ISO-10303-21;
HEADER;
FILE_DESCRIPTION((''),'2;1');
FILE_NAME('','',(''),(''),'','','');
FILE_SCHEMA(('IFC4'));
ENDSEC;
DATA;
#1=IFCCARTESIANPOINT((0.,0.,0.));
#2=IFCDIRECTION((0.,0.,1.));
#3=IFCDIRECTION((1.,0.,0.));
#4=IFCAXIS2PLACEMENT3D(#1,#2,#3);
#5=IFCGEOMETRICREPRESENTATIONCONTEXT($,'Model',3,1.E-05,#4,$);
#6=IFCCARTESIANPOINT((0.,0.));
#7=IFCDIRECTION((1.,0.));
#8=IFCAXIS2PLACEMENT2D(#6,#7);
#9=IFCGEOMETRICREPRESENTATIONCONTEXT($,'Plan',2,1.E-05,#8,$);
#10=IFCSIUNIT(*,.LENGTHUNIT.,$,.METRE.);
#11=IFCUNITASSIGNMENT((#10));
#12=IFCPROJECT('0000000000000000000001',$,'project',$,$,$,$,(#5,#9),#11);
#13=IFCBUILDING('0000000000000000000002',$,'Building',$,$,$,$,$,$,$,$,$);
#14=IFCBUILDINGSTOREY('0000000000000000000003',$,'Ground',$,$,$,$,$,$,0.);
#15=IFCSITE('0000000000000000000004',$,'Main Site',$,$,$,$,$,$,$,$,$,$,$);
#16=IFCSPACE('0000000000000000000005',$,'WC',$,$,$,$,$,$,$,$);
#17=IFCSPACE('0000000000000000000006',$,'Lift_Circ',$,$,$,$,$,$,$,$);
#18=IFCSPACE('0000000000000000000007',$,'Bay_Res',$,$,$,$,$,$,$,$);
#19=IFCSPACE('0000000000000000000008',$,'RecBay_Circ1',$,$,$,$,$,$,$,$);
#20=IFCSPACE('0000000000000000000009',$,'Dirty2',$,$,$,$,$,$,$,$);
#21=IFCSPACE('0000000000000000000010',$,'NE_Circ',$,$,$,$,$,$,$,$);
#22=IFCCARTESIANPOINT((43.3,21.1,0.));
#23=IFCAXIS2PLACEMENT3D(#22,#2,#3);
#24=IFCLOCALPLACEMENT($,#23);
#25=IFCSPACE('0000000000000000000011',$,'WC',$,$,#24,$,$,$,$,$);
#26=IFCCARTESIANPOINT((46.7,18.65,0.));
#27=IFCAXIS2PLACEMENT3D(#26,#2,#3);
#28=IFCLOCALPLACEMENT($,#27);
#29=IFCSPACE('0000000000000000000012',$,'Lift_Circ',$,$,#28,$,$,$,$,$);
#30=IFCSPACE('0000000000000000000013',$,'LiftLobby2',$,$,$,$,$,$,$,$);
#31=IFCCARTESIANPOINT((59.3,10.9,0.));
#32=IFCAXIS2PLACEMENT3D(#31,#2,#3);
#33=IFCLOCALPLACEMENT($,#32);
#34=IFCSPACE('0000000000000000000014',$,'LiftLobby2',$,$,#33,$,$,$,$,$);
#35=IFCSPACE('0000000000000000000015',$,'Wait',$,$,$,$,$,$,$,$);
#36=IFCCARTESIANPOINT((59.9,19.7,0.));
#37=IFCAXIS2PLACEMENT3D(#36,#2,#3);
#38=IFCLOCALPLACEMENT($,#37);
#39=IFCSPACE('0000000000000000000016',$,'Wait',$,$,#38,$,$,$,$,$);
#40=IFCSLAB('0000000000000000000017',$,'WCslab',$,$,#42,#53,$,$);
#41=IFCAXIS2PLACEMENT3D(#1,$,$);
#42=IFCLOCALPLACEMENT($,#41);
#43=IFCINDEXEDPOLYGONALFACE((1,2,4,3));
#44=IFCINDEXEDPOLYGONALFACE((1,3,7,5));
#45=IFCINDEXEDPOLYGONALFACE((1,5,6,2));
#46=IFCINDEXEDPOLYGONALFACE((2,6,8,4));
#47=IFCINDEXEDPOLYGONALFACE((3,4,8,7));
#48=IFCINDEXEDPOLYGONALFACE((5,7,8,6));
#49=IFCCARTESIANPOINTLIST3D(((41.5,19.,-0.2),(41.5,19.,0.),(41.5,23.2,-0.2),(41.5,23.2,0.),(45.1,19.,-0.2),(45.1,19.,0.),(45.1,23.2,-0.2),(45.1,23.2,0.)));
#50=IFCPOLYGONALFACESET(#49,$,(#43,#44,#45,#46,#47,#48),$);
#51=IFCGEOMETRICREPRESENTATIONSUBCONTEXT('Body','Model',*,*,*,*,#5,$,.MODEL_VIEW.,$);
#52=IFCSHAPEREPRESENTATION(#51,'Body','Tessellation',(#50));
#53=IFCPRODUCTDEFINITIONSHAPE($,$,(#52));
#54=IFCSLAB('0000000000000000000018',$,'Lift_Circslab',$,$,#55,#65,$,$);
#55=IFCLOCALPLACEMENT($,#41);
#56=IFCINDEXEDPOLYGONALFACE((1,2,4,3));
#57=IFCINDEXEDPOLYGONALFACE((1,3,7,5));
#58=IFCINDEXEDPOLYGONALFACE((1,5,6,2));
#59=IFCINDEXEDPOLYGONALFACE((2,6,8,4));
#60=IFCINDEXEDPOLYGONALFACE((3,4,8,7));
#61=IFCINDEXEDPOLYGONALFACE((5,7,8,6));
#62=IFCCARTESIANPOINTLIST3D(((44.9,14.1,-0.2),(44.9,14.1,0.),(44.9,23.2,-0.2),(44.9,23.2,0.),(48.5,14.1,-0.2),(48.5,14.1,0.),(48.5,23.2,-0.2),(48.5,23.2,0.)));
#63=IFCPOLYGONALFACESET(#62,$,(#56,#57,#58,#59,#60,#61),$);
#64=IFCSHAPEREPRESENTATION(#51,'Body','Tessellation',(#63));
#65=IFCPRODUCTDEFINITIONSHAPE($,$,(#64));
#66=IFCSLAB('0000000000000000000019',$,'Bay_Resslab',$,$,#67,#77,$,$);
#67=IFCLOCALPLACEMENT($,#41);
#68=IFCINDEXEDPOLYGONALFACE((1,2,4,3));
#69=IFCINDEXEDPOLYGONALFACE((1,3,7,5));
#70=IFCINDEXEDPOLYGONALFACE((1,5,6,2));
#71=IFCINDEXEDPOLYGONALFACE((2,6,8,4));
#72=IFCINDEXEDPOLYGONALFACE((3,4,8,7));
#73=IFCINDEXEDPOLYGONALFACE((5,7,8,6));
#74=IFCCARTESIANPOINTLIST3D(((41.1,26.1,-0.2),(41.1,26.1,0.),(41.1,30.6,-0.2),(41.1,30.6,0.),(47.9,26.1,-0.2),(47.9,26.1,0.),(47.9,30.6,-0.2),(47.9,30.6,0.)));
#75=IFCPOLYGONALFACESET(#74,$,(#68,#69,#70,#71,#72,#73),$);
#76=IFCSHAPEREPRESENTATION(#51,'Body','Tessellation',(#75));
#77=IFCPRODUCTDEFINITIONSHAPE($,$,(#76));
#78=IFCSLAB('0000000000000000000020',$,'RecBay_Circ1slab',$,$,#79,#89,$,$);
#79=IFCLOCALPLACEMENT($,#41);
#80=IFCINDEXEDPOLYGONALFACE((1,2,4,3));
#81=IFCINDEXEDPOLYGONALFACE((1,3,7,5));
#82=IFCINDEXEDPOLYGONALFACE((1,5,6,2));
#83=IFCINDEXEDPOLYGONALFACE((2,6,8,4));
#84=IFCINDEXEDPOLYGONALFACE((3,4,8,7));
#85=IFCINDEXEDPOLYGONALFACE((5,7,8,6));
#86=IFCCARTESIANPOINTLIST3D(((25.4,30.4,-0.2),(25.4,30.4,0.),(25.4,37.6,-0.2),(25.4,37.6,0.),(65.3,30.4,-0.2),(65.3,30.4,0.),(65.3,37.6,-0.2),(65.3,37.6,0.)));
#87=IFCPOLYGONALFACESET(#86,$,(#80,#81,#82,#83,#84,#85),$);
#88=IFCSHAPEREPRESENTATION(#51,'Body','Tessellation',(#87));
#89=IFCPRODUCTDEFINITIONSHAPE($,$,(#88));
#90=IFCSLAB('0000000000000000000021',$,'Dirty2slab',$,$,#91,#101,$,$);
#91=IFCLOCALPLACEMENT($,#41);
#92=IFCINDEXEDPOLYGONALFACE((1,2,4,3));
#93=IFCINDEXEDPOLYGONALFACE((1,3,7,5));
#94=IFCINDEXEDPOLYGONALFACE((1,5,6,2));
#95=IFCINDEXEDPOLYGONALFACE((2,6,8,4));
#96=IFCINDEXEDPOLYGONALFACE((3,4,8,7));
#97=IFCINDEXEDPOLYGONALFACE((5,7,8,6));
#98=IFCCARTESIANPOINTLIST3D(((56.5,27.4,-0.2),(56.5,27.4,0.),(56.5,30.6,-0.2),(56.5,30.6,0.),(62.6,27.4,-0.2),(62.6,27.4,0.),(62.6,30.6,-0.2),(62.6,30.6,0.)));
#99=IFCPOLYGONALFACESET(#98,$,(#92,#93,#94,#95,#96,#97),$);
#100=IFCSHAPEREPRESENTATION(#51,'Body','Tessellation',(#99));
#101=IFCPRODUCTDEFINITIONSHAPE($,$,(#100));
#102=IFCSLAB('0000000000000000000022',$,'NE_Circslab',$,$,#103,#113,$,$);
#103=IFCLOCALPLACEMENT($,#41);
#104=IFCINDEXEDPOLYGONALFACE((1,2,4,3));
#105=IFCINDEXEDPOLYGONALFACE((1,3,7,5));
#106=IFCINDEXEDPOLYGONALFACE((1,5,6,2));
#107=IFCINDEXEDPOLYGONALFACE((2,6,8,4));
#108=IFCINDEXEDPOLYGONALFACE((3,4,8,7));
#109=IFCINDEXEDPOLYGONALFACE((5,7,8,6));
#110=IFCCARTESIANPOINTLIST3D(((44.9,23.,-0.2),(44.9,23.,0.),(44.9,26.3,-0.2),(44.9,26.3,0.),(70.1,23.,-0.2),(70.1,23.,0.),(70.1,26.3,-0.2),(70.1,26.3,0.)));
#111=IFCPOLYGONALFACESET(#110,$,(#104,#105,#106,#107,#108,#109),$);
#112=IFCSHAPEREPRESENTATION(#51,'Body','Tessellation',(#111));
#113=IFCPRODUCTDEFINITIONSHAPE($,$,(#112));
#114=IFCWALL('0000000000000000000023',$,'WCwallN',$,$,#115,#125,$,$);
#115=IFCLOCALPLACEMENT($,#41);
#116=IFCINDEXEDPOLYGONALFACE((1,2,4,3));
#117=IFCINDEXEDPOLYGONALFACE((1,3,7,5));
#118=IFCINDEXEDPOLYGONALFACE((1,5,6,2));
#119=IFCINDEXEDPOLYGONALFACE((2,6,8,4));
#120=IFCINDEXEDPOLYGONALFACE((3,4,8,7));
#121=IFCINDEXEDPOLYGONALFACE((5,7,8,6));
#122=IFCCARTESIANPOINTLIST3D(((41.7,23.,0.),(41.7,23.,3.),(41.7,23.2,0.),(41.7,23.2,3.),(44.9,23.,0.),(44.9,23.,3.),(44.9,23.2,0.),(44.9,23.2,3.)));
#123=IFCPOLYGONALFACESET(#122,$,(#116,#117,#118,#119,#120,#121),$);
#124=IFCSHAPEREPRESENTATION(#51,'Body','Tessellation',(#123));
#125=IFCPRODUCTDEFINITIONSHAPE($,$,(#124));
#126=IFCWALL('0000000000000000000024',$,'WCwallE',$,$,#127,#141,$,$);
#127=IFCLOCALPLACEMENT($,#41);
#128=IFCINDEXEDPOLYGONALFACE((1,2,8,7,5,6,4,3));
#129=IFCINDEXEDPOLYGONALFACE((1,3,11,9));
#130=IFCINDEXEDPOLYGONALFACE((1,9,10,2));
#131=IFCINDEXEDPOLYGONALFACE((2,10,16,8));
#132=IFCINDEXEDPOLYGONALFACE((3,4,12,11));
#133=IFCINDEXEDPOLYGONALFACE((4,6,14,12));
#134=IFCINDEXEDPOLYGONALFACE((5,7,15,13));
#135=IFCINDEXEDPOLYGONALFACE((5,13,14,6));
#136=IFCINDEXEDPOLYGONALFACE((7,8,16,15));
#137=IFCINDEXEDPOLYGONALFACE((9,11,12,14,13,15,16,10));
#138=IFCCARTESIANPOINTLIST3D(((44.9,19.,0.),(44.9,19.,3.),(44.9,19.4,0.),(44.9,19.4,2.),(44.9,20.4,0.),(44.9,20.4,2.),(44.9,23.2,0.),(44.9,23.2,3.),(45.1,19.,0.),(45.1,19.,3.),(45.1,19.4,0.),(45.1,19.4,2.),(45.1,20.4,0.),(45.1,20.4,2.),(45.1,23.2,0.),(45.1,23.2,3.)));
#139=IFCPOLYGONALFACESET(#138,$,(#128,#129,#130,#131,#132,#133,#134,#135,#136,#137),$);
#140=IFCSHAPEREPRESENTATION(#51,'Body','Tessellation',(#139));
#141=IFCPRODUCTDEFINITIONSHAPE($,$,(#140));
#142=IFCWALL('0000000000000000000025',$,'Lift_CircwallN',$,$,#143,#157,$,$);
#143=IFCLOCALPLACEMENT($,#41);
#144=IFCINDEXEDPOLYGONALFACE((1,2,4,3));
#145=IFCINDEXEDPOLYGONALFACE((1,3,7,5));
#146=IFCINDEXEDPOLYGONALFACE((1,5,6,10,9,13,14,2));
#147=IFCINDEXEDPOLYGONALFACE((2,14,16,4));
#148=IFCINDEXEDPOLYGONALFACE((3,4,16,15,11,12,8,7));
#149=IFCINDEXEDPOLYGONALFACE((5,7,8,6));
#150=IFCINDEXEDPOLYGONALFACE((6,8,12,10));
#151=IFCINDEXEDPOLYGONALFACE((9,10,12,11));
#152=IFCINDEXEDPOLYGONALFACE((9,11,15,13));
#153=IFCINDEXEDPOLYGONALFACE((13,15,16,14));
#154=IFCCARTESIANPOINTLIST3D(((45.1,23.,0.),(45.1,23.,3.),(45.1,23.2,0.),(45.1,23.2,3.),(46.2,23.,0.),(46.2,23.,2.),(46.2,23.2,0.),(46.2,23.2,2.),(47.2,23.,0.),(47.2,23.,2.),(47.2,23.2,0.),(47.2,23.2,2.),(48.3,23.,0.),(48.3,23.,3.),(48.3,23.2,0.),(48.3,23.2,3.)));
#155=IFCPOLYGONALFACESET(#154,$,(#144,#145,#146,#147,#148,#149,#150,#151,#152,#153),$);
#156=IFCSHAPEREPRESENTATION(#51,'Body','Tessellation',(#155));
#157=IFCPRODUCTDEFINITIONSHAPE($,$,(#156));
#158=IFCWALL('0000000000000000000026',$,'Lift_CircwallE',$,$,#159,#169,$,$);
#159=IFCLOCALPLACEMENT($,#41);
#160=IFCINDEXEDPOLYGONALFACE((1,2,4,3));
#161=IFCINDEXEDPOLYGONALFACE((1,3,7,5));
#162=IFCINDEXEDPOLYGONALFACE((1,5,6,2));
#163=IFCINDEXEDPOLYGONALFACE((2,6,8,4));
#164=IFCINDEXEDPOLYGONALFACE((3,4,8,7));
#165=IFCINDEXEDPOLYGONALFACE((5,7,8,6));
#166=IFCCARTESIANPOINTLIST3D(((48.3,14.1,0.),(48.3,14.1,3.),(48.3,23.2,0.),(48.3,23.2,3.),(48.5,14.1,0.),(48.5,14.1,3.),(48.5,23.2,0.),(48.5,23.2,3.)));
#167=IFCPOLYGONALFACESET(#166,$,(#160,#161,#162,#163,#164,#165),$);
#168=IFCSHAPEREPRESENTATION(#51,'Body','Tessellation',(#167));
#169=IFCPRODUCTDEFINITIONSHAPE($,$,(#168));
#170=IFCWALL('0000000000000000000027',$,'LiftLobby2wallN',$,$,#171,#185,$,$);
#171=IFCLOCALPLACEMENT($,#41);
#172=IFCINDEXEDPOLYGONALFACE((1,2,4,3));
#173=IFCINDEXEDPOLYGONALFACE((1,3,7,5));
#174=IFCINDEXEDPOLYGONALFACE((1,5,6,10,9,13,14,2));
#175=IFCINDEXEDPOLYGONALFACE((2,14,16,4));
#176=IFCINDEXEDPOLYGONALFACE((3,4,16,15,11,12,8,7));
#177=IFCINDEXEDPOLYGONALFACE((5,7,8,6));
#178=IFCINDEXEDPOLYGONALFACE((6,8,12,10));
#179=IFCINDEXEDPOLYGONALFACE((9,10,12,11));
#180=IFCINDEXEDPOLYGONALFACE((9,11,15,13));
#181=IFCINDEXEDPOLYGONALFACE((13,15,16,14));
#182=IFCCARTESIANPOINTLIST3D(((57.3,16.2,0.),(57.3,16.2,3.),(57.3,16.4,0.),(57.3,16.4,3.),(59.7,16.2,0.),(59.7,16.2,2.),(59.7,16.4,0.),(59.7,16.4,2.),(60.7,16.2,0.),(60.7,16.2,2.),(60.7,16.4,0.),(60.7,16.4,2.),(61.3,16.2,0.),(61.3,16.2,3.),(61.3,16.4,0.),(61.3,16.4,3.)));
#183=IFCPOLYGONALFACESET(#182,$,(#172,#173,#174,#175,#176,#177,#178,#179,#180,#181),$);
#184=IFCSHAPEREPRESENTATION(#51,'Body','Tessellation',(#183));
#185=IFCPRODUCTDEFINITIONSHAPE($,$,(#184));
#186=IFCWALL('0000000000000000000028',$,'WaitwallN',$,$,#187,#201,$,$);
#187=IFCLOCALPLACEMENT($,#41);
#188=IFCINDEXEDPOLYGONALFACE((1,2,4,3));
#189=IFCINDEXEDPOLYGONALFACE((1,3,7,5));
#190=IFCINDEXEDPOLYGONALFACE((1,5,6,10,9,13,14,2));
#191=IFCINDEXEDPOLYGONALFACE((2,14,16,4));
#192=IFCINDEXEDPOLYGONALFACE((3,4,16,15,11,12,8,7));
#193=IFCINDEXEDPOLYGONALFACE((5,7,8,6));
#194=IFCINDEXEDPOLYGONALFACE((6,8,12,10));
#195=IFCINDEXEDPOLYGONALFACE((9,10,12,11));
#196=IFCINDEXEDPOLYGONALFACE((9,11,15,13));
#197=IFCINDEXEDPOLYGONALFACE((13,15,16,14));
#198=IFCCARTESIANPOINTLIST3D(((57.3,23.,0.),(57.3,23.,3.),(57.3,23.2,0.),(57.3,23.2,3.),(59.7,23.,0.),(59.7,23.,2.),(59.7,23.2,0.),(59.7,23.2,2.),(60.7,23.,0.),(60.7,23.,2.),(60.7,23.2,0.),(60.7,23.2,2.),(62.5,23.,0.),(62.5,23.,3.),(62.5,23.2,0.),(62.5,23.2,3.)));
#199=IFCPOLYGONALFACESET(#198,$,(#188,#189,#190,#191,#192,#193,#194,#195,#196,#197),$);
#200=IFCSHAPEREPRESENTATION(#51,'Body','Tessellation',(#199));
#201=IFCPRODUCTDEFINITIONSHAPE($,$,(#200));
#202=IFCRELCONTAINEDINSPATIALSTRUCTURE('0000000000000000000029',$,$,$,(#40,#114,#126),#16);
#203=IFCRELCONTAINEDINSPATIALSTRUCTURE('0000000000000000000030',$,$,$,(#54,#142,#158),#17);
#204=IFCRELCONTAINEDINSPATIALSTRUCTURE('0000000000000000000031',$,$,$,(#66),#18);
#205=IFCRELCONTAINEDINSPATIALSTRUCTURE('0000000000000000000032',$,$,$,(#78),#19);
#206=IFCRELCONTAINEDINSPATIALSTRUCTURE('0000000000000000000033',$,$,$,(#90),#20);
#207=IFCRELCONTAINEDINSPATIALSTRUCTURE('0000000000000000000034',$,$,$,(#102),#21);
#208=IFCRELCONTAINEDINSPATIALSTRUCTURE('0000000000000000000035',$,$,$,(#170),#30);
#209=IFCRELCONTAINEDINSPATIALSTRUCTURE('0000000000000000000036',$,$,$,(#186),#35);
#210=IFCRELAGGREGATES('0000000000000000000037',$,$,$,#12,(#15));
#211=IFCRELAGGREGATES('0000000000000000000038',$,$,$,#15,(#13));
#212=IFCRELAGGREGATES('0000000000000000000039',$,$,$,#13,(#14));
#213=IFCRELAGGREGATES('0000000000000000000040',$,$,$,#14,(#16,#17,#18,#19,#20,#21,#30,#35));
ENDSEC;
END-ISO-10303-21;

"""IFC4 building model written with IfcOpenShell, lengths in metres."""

from ifc_helpers import new_model, si_unit, frame, origin_with_axes, origin_2d_with_axis, place, context, subcontext, project, spatial, indexed_curve, rectangle, outline, extrude, element, save


model = new_model("IFC4")

# Units and contexts
model_context = context("Model", 3, precision=1e-05, world=origin_with_axes())
plan_context = context("Plan", 2, precision=1e-05, world=origin_2d_with_axis())
body_context = subcontext(model_context, "Body", "Model", "MODEL_VIEW")
ifc_project = project(units=[si_unit("LENGTHUNIT", "METRE")], contexts=[model_context, plan_context])

# Site, building, storey, space
site = spatial("IfcSite", under=ifc_project, Name="Main Site")
building = spatial("IfcBuilding", under=site, Name="Building")
storey = spatial("IfcBuildingStorey", under=building, Name="Ground", Elevation=0.0)
space_1 = spatial("IfcSpace", under=storey, Name="WC")

# Slab
slab_1_placement = place(None, frame((43.3, 21.1, -0.2), z_axis=(0.0, 0.0, 1.0), x_axis=(1.0, 0.0, 0.0)))
element("IfcSlab", 1, at=slab_1_placement, inside=space_1, Name="WCslab", context=body_context, shape_type="SweptSolid", body=[
    extrude(rectangle(XDim=3.6, YDim=4.2), origin_with_axes(), (0.0, 0.0, 1.0), 0.2),
])

# Shared definitions
space_2 = spatial("IfcSpace", under=storey, Name="Lift_Circ")

# Slab
slab_2_placement = place(None, frame((46.7, 18.65, -0.2), z_axis=(0.0, 0.0, 1.0), x_axis=(1.0, 0.0, 0.0)))
element("IfcSlab", 2, at=slab_2_placement, inside=space_2, Name="Lift_Circslab", context=body_context, shape_type="SweptSolid", body=[
    extrude(rectangle(XDim=3.6, YDim=9.1), origin_with_axes(), (0.0, 0.0, 1.0), 0.2),
])

# Shared definitions
space_3 = spatial("IfcSpace", under=storey, Name="Bay_Res")

# Slab
slab_3_placement = place(None, frame((44.5, 28.35, -0.2), z_axis=(0.0, 0.0, 1.0), x_axis=(1.0, 0.0, 0.0)))
element("IfcSlab", 3, at=slab_3_placement, inside=space_3, Name="Bay_Resslab", context=body_context, shape_type="SweptSolid", body=[
    extrude(rectangle(XDim=6.8, YDim=4.5), origin_with_axes(), (0.0, 0.0, 1.0), 0.2),
])

# Shared definitions
space_4 = spatial("IfcSpace", under=storey, Name="RecBay_Circ1")

# Slab
slab_4_placement = place(None, frame((45.35, 34.0, -0.2), z_axis=(0.0, 0.0, 1.0), x_axis=(1.0, 0.0, 0.0)))
element("IfcSlab", 4, at=slab_4_placement, inside=space_4, Name="RecBay_Circ1slab", context=body_context, shape_type="SweptSolid", body=[
    extrude(rectangle(XDim=39.9, YDim=7.2), origin_with_axes(), (0.0, 0.0, 1.0), 0.2),
])

# Shared definitions
space_5 = spatial("IfcSpace", under=storey, Name="Dirty2")

# Slab
slab_5_placement = place(None, frame((59.55, 29.0, -0.2), z_axis=(0.0, 0.0, 1.0), x_axis=(1.0, 0.0, 0.0)))
element("IfcSlab", 5, at=slab_5_placement, inside=space_5, Name="Dirty2slab", context=body_context, shape_type="SweptSolid", body=[
    extrude(rectangle(XDim=6.1, YDim=3.2), origin_with_axes(), (0.0, 0.0, 1.0), 0.2),
])

# Shared definitions
space_6 = spatial("IfcSpace", under=storey, Name="NE_Circ")

# Slab
slab_6_placement = place(None, frame((57.5, 24.65, -0.2), z_axis=(0.0, 0.0, 1.0), x_axis=(1.0, 0.0, 0.0)))
element("IfcSlab", 6, at=slab_6_placement, inside=space_6, Name="NE_Circslab", context=body_context, shape_type="SweptSolid", body=[
    extrude(rectangle(XDim=25.2, YDim=3.3), origin_with_axes(), (0.0, 0.0, 1.0), 0.2),
])

# Walls
wall_1_placement = place(None, frame((41.7, 23.0, 0.0), z_axis=(0.0, 0.0, 1.0), x_axis=(1.0, 0.0, 0.0)))
element("IfcWall", 7, at=wall_1_placement, inside=space_1, Name="WCwallN", context=body_context, shape_type="SweptSolid", body=[
    extrude(outline(indexed_curve([(0.0, 0.0), (0.0, 0.2), (3.2, 0.2), (3.2, 0.0), (0.0, 0.0)], self_intersect=False)), origin_with_axes(), (0.0, 0.0, 1.0), 3.0),
])
wall_2_placement = place(None, frame((45.1, 19.0, 0.0), z_axis=(0.0, 0.0, 1.0), x_axis=(0.0, 1.0, 0.0)))
wall_2 = element("IfcWall", 8, at=wall_2_placement, inside=space_1, Name="WCwallE", context=body_context, shape_type="SweptSolid", body=[
    extrude(outline(indexed_curve([(0.0, 0.0), (0.0, 0.2), (4.2, 0.2), (4.2, 0.0), (0.0, 0.0)], self_intersect=False)), origin_with_axes(), (0.0, 0.0, 1.0), 3.0),
])

# Shared definitions
space_7_placement = place(None, frame((43.3, 21.1, 0.0), z_axis=(0.0, 0.0, 1.0), x_axis=(1.0, 0.0, 0.0)))
space_7 = spatial("IfcSpace", at=space_7_placement, Name="WC")

# Opening
opening_1_placement = place(wall_2_placement, frame((0.4, 0.0, 0.0), z_axis=(0.0, 0.0, 1.0), x_axis=(1.0, 0.0, 0.0)))
element("IfcOpeningElement", 9, at=opening_1_placement, inside=space_7, cuts=wall_2, context=body_context, shape_type="SweptSolid", body=[
    extrude(outline(indexed_curve([(0.0, 0.0), (0.0, 0.4), (1.0, 0.4), (1.0, 0.0), (0.0, 0.0)], self_intersect=False)), origin_with_axes(), (0.0, 0.0, 1.0), 2.0),
])

# Wall
wall_3_placement = place(None, frame((45.1, 23.0, 0.0), z_axis=(0.0, 0.0, 1.0), x_axis=(1.0, 0.0, 0.0)))
wall_3 = element("IfcWall", 10, at=wall_3_placement, inside=space_2, Name="Lift_CircwallN", context=body_context, shape_type="SweptSolid", body=[
    extrude(outline(indexed_curve([(0.0, 0.0), (0.0, 0.2), (3.2, 0.2), (3.2, 0.0), (0.0, 0.0)], self_intersect=False)), origin_with_axes(), (0.0, 0.0, 1.0), 3.0),
])

# Shared definitions
space_8_placement = place(None, frame((46.7, 18.65, 0.0), z_axis=(0.0, 0.0, 1.0), x_axis=(1.0, 0.0, 0.0)))
space_8 = spatial("IfcSpace", at=space_8_placement, Name="Lift_Circ")

# Opening
opening_2_placement = place(wall_3_placement, frame((1.1, 0.0, 0.0), z_axis=(0.0, 0.0, 1.0), x_axis=(1.0, 0.0, 0.0)))
element("IfcOpeningElement", 11, at=opening_2_placement, inside=space_8, cuts=wall_3, context=body_context, shape_type="SweptSolid", body=[
    extrude(outline(indexed_curve([(0.0, 0.0), (0.0, 0.4), (1.0, 0.4), (1.0, 0.0), (0.0, 0.0)], self_intersect=False)), origin_with_axes(), (0.0, 0.0, 1.0), 2.0),
])

# Wall
wall_4_placement = place(None, frame((48.5, 14.1, 0.0), z_axis=(0.0, 0.0, 1.0), x_axis=(0.0, 1.0, 0.0)))
element("IfcWall", 12, at=wall_4_placement, inside=space_2, Name="Lift_CircwallE", context=body_context, shape_type="SweptSolid", body=[
    extrude(outline(indexed_curve([(0.0, 0.0), (0.0, 0.2), (9.1, 0.2), (9.1, 0.0), (0.0, 0.0)], self_intersect=False)), origin_with_axes(), (0.0, 0.0, 1.0), 3.0),
])

# Shared definitions
space_9 = spatial("IfcSpace", under=storey, Name="LiftLobby2")

# Wall
wall_5_placement = place(None, frame((57.3, 16.2, 0.0), z_axis=(0.0, 0.0, 1.0), x_axis=(1.0, 0.0, 0.0)))
wall_5 = element("IfcWall", 13, at=wall_5_placement, inside=space_9, Name="LiftLobby2wallN", context=body_context, shape_type="SweptSolid", body=[
    extrude(outline(indexed_curve([(0.0, 0.0), (0.0, 0.2), (4.0, 0.2), (4.0, 0.0), (0.0, 0.0)], self_intersect=False)), origin_with_axes(), (0.0, 0.0, 1.0), 3.0),
])

# Shared definitions
space_10_placement = place(None, frame((59.3, 10.9, 0.0), z_axis=(0.0, 0.0, 1.0), x_axis=(1.0, 0.0, 0.0)))
space_10 = spatial("IfcSpace", at=space_10_placement, Name="LiftLobby2")

# Opening
opening_3_placement = place(wall_5_placement, frame((2.4, 0.0, 0.0), z_axis=(0.0, 0.0, 1.0), x_axis=(1.0, 0.0, 0.0)))
element("IfcOpeningElement", 14, at=opening_3_placement, inside=space_10, cuts=wall_5, context=body_context, shape_type="SweptSolid", body=[
    extrude(outline(indexed_curve([(0.0, 0.0), (0.0, 0.4), (1.0, 0.4), (1.0, 0.0), (0.0, 0.0)], self_intersect=False)), origin_with_axes(), (0.0, 0.0, 1.0), 2.0),
])

# Shared definitions
space_11 = spatial("IfcSpace", under=storey, Name="Wait")

# Wall
wall_6_placement = place(None, frame((57.3, 23.0, 0.0), z_axis=(0.0, 0.0, 1.0), x_axis=(1.0, 0.0, 0.0)))
wall_6 = element("IfcWall", 15, at=wall_6_placement, inside=space_11, Name="WaitwallN", context=body_context, shape_type="SweptSolid", body=[
    extrude(outline(indexed_curve([(0.0, 0.0), (0.0, 0.2), (5.2, 0.2), (5.2, 0.0), (0.0, 0.0)], self_intersect=False)), origin_with_axes(), (0.0, 0.0, 1.0), 3.0),
])

# Shared definitions
space_12_placement = place(None, frame((59.9, 19.7, 0.0), z_axis=(0.0, 0.0, 1.0), x_axis=(1.0, 0.0, 0.0)))
space_12 = spatial("IfcSpace", at=space_12_placement, Name="Wait")

# Opening
opening_4_placement = place(wall_6_placement, frame((2.4, 0.0, 0.0), z_axis=(0.0, 0.0, 1.0), x_axis=(1.0, 0.0, 0.0)))
element("IfcOpeningElement", 16, at=opening_4_placement, inside=space_12, cuts=wall_6, context=body_context, shape_type="SweptSolid", body=[
    extrude(outline(indexed_curve([(0.0, 0.0), (0.0, 0.4), (1.0, 0.4), (1.0, 0.0), (0.0, 0.0)], self_intersect=False)), origin_with_axes(), (0.0, 0.0, 1.0), 2.0),
])

save(model, "model.ifc")
